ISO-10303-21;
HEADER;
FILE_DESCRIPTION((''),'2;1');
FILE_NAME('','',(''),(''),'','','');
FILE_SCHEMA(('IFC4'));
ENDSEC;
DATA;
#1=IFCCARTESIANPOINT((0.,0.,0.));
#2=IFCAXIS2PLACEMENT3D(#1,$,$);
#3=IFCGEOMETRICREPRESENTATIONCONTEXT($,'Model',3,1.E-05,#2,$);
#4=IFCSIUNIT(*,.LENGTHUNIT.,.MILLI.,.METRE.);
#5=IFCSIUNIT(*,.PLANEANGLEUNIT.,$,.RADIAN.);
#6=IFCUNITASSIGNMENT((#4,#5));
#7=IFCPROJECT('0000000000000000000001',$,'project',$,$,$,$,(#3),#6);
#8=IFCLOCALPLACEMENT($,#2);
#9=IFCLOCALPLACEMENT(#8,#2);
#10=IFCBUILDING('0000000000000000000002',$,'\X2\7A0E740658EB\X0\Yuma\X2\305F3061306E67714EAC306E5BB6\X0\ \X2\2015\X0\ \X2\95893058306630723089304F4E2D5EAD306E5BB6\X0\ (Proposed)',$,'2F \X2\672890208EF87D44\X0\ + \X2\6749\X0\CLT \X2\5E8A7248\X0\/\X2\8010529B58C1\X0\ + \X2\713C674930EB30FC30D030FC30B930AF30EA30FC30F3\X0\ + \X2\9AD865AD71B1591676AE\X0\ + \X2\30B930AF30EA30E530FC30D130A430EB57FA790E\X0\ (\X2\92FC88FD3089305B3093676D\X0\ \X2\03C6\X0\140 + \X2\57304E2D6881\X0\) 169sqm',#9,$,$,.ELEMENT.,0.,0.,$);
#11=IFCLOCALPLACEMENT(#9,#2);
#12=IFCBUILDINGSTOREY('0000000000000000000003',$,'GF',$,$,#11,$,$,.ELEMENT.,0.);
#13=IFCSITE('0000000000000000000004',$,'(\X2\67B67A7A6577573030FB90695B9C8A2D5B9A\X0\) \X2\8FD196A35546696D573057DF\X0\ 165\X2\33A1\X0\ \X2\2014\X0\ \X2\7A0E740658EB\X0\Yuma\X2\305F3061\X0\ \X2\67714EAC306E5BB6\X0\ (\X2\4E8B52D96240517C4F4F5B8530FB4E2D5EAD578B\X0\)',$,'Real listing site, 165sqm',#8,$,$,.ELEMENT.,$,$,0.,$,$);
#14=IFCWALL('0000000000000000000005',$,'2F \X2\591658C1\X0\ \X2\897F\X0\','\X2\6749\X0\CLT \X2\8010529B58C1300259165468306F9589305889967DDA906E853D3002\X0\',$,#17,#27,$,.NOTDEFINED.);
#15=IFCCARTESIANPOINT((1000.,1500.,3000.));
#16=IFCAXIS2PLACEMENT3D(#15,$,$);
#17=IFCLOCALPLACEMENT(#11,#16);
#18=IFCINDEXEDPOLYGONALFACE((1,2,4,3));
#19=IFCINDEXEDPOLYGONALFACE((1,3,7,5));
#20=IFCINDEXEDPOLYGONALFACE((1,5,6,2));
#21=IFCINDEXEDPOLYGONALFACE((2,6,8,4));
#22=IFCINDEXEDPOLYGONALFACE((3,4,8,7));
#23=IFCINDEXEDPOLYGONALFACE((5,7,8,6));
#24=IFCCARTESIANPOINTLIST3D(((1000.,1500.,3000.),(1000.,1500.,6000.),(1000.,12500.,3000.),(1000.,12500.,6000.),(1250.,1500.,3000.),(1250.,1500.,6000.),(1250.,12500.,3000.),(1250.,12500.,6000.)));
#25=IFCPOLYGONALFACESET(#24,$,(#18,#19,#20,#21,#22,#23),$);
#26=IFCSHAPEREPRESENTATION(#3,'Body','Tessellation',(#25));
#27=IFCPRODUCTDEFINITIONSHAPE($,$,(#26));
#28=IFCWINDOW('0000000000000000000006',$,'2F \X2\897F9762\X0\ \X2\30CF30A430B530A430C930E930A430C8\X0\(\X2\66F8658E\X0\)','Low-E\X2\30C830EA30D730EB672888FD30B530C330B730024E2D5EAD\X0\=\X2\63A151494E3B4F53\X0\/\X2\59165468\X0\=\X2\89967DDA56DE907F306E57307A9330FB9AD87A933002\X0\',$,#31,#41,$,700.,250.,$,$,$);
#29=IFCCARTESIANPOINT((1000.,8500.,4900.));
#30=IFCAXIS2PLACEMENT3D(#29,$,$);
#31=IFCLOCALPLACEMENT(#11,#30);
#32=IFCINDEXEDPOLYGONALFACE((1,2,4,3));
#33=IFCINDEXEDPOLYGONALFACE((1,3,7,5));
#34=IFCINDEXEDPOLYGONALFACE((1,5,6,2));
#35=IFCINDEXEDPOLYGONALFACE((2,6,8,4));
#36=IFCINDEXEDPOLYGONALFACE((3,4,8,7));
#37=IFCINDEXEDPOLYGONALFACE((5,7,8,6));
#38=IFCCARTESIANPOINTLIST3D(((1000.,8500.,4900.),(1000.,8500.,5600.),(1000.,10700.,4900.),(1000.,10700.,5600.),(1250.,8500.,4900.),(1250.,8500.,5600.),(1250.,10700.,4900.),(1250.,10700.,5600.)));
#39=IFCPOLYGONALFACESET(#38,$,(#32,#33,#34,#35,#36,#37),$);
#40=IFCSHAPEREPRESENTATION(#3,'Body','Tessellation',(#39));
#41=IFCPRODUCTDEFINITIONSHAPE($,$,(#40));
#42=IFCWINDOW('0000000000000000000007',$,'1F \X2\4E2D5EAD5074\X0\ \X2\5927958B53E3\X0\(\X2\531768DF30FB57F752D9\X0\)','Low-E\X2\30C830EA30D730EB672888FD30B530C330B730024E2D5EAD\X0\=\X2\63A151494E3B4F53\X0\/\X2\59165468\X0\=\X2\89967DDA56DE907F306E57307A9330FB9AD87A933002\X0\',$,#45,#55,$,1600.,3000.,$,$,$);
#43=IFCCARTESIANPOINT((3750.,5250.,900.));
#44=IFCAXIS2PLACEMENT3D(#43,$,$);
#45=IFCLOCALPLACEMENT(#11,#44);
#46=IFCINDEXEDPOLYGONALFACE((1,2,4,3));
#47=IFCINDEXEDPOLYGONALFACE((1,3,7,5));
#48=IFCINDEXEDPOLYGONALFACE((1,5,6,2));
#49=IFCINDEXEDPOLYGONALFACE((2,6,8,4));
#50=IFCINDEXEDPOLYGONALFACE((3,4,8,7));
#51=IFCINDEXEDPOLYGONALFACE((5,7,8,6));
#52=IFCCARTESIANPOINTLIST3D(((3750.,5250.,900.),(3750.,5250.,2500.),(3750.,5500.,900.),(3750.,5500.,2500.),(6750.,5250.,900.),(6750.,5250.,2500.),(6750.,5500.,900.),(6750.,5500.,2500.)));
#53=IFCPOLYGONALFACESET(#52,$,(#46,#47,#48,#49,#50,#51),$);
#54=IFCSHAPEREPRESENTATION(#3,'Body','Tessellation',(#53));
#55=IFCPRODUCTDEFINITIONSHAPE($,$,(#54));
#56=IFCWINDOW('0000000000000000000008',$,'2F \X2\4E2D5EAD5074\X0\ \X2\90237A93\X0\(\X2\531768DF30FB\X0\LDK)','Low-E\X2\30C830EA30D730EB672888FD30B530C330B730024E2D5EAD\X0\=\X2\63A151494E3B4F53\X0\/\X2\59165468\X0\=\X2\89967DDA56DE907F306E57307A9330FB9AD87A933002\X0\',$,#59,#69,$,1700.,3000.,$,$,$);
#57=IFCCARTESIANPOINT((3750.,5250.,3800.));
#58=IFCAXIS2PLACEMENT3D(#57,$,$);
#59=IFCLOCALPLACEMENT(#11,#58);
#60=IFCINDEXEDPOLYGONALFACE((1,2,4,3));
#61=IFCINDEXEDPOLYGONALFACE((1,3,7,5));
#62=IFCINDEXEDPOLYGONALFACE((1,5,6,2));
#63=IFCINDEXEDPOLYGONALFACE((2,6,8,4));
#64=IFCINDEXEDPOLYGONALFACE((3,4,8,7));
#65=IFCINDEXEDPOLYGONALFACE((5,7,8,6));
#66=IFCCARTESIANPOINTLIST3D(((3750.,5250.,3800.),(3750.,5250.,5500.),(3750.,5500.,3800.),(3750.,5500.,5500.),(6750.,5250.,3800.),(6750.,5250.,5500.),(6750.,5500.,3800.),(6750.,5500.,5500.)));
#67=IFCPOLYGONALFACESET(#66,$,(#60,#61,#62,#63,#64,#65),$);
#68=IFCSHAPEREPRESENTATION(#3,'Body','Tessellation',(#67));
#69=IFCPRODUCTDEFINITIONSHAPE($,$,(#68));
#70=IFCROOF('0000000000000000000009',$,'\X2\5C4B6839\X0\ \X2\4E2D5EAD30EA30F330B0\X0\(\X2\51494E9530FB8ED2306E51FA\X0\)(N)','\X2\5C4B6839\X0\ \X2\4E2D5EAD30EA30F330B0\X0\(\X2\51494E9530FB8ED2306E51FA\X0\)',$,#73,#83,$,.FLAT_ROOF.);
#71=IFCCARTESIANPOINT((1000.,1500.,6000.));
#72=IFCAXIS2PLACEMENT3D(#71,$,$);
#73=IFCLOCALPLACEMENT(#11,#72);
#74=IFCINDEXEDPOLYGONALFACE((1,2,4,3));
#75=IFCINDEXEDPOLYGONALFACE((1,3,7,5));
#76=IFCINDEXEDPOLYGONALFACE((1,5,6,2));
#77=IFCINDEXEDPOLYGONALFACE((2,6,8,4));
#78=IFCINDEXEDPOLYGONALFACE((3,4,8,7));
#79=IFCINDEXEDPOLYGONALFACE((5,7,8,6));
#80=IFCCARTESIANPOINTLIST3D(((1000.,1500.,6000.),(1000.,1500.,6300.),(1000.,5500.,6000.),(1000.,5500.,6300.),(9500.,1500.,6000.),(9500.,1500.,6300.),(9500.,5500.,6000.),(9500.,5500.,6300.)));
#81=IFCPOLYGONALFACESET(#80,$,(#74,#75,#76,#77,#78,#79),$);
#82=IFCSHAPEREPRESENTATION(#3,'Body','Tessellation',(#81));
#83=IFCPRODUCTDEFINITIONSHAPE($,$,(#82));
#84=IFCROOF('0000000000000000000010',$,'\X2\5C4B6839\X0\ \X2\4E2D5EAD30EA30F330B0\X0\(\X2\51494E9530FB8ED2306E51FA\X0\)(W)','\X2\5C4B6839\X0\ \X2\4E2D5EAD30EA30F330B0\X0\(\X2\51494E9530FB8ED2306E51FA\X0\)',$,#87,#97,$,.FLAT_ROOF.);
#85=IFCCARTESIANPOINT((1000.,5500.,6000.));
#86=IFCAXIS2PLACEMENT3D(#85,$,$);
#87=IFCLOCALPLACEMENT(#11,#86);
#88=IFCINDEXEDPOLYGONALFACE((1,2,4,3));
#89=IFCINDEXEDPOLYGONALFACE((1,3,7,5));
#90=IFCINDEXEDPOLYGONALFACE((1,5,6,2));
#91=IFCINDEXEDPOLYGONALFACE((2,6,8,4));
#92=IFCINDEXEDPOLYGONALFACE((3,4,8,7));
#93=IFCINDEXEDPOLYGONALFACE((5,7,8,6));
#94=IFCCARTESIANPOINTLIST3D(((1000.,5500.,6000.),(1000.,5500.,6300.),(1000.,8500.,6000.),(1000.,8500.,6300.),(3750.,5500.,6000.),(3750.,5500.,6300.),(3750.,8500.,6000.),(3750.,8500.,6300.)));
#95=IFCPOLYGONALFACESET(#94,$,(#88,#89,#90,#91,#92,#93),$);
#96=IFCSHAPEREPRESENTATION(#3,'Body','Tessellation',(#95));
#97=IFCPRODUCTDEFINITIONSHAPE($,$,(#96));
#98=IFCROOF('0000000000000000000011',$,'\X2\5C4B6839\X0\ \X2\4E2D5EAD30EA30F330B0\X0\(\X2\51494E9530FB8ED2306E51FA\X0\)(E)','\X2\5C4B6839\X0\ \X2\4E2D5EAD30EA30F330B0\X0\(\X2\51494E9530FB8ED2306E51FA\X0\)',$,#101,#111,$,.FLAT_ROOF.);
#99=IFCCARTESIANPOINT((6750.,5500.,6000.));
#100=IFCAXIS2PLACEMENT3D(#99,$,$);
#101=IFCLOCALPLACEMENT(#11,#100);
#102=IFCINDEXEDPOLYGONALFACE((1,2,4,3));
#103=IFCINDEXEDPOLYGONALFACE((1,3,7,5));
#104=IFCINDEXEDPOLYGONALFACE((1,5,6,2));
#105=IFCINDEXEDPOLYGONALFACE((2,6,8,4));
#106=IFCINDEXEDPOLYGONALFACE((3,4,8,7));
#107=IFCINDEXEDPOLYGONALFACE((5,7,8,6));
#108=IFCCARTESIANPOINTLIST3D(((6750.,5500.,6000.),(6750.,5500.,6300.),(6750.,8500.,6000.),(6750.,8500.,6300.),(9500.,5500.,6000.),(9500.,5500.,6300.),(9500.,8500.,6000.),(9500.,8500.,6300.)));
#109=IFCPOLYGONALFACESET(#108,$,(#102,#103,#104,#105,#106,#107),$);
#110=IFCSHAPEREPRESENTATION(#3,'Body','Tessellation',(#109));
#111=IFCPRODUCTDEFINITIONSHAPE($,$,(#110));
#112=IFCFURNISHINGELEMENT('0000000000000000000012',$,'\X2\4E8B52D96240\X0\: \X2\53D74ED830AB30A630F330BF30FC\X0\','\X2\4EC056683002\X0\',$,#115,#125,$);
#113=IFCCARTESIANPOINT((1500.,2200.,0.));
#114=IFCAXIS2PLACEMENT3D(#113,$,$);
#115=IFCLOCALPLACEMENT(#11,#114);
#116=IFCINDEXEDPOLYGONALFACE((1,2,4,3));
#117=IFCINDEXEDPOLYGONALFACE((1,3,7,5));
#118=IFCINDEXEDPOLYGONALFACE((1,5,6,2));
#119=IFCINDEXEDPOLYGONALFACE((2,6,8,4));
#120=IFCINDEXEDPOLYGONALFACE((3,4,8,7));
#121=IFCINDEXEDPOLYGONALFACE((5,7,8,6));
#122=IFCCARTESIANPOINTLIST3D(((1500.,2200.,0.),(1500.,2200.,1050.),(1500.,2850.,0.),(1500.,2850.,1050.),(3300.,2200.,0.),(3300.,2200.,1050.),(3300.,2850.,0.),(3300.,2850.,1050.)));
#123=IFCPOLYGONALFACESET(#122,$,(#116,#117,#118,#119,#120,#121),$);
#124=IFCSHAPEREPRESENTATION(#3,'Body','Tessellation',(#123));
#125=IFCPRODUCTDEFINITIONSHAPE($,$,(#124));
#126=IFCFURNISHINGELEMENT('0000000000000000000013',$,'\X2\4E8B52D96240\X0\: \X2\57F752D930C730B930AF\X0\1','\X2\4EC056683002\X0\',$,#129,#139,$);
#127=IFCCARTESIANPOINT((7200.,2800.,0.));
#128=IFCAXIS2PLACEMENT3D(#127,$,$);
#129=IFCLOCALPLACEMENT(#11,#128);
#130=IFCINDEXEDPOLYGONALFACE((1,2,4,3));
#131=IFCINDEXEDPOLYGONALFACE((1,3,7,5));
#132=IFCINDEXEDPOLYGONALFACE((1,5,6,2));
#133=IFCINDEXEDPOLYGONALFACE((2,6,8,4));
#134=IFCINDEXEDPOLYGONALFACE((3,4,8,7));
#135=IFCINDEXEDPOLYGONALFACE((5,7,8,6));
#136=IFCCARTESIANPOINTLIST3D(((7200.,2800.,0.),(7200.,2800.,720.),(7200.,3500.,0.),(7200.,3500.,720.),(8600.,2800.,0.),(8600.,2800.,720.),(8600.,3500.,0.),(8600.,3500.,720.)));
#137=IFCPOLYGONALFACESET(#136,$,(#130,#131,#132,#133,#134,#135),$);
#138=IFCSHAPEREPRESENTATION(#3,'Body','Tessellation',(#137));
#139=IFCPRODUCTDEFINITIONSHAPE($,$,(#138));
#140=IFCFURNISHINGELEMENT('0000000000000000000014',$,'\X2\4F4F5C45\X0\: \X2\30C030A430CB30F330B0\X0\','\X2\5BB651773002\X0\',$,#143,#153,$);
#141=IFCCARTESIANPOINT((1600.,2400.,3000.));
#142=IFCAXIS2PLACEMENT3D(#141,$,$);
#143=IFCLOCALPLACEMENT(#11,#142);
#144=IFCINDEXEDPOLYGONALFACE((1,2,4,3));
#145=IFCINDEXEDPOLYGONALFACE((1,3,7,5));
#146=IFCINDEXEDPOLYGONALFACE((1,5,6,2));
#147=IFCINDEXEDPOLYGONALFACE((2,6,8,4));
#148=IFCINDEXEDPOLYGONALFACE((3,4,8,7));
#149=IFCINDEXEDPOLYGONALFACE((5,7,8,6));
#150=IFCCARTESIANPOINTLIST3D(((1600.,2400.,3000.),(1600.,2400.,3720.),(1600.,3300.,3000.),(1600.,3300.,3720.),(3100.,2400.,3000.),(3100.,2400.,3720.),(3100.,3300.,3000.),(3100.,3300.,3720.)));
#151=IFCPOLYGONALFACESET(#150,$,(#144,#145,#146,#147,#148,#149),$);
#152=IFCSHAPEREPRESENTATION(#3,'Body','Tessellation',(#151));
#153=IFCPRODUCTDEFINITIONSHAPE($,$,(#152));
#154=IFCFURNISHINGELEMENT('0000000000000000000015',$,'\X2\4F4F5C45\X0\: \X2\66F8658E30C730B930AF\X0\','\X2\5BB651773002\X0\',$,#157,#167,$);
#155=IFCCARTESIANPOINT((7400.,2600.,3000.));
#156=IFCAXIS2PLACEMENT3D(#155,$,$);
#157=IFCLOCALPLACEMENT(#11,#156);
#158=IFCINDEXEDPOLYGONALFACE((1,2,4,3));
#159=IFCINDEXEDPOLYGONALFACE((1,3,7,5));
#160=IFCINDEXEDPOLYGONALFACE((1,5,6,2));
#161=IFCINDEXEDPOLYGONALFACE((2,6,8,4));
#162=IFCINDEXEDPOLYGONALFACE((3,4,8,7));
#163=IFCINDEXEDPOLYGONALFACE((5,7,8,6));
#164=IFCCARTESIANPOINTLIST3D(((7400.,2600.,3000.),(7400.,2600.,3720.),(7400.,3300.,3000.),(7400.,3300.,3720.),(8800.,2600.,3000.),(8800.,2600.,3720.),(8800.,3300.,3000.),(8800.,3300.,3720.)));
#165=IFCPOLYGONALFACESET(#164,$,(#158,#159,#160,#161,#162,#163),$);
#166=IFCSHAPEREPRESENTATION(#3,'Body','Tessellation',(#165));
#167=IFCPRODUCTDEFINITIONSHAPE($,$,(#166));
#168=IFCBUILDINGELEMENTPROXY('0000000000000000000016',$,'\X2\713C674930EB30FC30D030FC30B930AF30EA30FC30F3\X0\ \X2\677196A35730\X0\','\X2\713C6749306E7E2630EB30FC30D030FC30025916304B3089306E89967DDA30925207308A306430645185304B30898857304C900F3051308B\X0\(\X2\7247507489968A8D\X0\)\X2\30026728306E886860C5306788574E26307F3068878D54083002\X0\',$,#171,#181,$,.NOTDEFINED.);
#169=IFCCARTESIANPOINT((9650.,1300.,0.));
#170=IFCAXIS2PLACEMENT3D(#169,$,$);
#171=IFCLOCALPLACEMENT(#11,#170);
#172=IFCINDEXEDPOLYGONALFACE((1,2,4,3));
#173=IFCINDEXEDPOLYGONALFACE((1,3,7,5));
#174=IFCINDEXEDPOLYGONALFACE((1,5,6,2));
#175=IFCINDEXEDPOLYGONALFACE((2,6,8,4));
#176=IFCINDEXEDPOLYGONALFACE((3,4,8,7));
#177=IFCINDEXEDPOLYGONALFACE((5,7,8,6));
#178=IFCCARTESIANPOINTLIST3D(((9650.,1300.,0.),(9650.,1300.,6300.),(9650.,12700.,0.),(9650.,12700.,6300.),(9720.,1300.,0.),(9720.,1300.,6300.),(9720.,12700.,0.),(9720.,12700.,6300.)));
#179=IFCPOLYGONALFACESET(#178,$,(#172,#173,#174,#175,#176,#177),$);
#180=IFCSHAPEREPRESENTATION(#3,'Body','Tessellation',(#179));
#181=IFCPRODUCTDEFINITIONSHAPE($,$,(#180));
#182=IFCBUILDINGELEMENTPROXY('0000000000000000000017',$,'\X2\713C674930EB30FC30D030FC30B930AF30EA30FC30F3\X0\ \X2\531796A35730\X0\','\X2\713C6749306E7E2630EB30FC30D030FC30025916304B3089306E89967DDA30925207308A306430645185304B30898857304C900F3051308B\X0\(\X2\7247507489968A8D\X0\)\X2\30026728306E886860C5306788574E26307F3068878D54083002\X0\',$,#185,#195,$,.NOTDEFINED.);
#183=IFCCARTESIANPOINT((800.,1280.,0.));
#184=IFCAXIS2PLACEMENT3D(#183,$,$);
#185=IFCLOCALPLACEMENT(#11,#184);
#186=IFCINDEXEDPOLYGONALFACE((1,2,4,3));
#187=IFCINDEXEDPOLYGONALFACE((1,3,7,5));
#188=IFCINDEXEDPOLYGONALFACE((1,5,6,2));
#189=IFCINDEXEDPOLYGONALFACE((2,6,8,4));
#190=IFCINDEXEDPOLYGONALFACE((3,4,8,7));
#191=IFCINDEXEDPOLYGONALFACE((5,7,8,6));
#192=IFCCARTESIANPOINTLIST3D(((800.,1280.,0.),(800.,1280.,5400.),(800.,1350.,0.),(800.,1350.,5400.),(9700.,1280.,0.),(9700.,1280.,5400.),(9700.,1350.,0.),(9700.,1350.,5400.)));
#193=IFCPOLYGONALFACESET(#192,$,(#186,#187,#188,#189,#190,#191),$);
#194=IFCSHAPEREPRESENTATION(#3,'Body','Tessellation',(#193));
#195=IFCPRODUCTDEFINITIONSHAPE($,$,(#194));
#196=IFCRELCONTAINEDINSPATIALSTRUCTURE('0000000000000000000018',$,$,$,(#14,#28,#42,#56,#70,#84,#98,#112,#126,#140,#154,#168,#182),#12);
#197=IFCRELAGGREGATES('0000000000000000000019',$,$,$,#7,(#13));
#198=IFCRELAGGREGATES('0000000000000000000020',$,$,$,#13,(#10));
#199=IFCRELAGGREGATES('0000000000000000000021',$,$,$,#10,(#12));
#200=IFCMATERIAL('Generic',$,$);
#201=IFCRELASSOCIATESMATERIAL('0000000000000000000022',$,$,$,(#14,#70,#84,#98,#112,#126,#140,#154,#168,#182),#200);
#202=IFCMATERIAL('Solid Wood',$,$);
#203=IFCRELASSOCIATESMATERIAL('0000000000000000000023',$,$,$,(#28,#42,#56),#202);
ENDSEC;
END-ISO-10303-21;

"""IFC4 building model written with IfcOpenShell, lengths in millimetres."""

from ifc_helpers import new_model, si_unit, frame, frame_2d, origin, place, context, project, spatial, rectangle, extrude, material, element, fill, save


model = new_model("IFC4")

# Units and contexts
model_context = context("Model", 3, precision=1e-05, world=origin())
ifc_project = project(units=[si_unit("LENGTHUNIT", "METRE", prefix="MILLI"), si_unit("PLANEANGLEUNIT", "RADIAN")], contexts=[model_context])

# Site, building, storey
site_placement = place(None, origin())
site = spatial("IfcSite", under=ifc_project, at=site_placement, Name="(架空敷地・適宜設定) 近隣商業地域 165㎡ — 税理士Yumaたち 東京の家 (事務所兼住宅・中庭型)", ObjectType="Real listing site, 165sqm", CompositionType="ELEMENT", RefElevation=0.0)
building_placement = place(site_placement, origin())
building = spatial("IfcBuilding", under=site, at=building_placement, Name="税理士Yumaたちの東京の家 ― 閉じてひらく中庭の家 (Proposed)", ObjectType="2F 木造軸組 + 杉CLT 床版/耐力壁 + 焼杉ルーバースクリーン + 高断熱外皮 + スクリューパイル基礎 (鋼製らせん杭 φ140 + 地中梁) 169sqm", CompositionType="ELEMENT", ElevationOfRefHeight=0.0, ElevationOfTerrain=0.0)
storey_placement = place(building_placement, origin())
storey = spatial("IfcBuildingStorey", under=building, at=storey_placement, Name="GF", CompositionType="ELEMENT", Elevation=0.0)

# Shared definitions
ifc_material_1 = material(Name="Generic")

# Shared definitions
ifc_material_2 = material(Name="Solid Wood")

# Wall, opening, window
wall_1_placement = place(storey_placement, frame((1000.0, 1500.0, 3000.0)))
wall_1 = element("IfcWall", 1, at=wall_1_placement, inside=storey, material=ifc_material_1, Name="2F 外壁 西", Description="杉CLT 耐力壁。外周は閉じ視線遮蔽。", PredefinedType="NOTDEFINED", context=model_context, shape_type="SweptSolid", body=[
    extrude(rectangle(XDim=250.0, YDim=11000.0, at=frame_2d((125.0, 5500.0))), frame((1000.0, 1500.0, 3000.0)), (0.0, 0.0, 1.0), 3000.0),
])
opening_1_placement = place(storey_placement, frame((1000.0, 8500.0, 4900.0)))
opening_1 = element("IfcOpeningElement", 2, at=opening_1_placement, cuts=wall_1, PredefinedType="NOTDEFINED", context=model_context, shape_type="SweptSolid", body=[
    extrude(rectangle(XDim=250.0, YDim=2200.0, at=frame_2d((125.0, 1100.0))), frame((1000.0, 8500.0, 4900.0)), (0.0, 0.0, 1.0), 700.0),
])
window_1_placement = place(storey_placement, frame((1000.0, 8500.0, 4900.0)))
window_1 = element("IfcWindow", 3, at=window_1_placement, inside=storey, material=ifc_material_2, Name="2F 西面 ハイサイドライト(書斎)", Description="Low-Eトリプル木製サッシ。中庭=採光主体/外周=視線回避の地窓・高窓。", OverallHeight=700.0, OverallWidth=250.0, context=model_context, shape_type="SweptSolid", body=[
    extrude(rectangle(XDim=250.0, YDim=2200.0, at=frame_2d((125.0, 1100.0))), frame((1000.0, 8500.0, 4900.0)), (0.0, 0.0, 1.0), 700.0),
])
fill(opening_1, window_1)

# Windows
window_2_placement = place(storey_placement, frame((3750.0, 5250.0, 900.0)))
element("IfcWindow", 4, at=window_2_placement, inside=storey, material=ifc_material_2, Name="1F 中庭側 大開口(北棟・執務)", Description="Low-Eトリプル木製サッシ。中庭=採光主体/外周=視線回避の地窓・高窓。", OverallHeight=1600.0, OverallWidth=3000.0, context=model_context, shape_type="SweptSolid", body=[
    extrude(rectangle(XDim=3000.0, YDim=250.0, at=frame_2d((1500.0, 125.0))), frame((3750.0, 5250.0, 900.0)), (0.0, 0.0, 1.0), 1600.0),
])
window_3_placement = place(storey_placement, frame((3750.0, 5250.0, 3800.0)))
element("IfcWindow", 5, at=window_3_placement, inside=storey, material=ifc_material_2, Name="2F 中庭側 連窓(北棟・LDK)", Description="Low-Eトリプル木製サッシ。中庭=採光主体/外周=視線回避の地窓・高窓。", OverallHeight=1700.0, OverallWidth=3000.0, context=model_context, shape_type="SweptSolid", body=[
    extrude(rectangle(XDim=3000.0, YDim=250.0, at=frame_2d((1500.0, 125.0))), frame((3750.0, 5250.0, 3800.0)), (0.0, 0.0, 1.0), 1700.0),
])

# Roofs
roof_1_placement = place(storey_placement, frame((1000.0, 1500.0, 6000.0)))
element("IfcRoof", 6, at=roof_1_placement, inside=storey, material=ifc_material_1, Name="屋根 中庭リング(光井・軒の出)(N)", Description="屋根 中庭リング(光井・軒の出)", PredefinedType="FLAT_ROOF", context=model_context, shape_type="SweptSolid", body=[
    extrude(rectangle(XDim=8500.0, YDim=4000.0, at=frame_2d((4250.0, 2000.0))), frame((1000.0, 1500.0, 6000.0)), (0.0, 0.0, 1.0), 300.0),
])
roof_2_placement = place(storey_placement, frame((1000.0, 5500.0, 6000.0)))
element("IfcRoof", 7, at=roof_2_placement, inside=storey, material=ifc_material_1, Name="屋根 中庭リング(光井・軒の出)(W)", Description="屋根 中庭リング(光井・軒の出)", PredefinedType="FLAT_ROOF", context=model_context, shape_type="SweptSolid", body=[
    extrude(rectangle(XDim=2750.0, YDim=3000.0, at=frame_2d((1375.0, 1500.0))), frame((1000.0, 5500.0, 6000.0)), (0.0, 0.0, 1.0), 300.0),
])
roof_3_placement = place(storey_placement, frame((6750.0, 5500.0, 6000.0)))
element("IfcRoof", 8, at=roof_3_placement, inside=storey, material=ifc_material_1, Name="屋根 中庭リング(光井・軒の出)(E)", Description="屋根 中庭リング(光井・軒の出)", PredefinedType="FLAT_ROOF", context=model_context, shape_type="SweptSolid", body=[
    extrude(rectangle(XDim=2750.0, YDim=3000.0, at=frame_2d((1375.0, 1500.0))), frame((6750.0, 5500.0, 6000.0)), (0.0, 0.0, 1.0), 300.0),
])

# Furnishing elements
furnishing_1_placement = place(storey_placement, frame((1500.0, 2200.0, 0.0)))
element("IfcFurnishingElement", 9, at=furnishing_1_placement, inside=storey, material=ifc_material_1, Name="事務所: 受付カウンター", Description="什器。", context=model_context, shape_type="SweptSolid", body=[
    extrude(rectangle(XDim=1800.0, YDim=650.0, at=frame_2d((900.0, 325.0))), frame((1500.0, 2200.0, 0.0)), (0.0, 0.0, 1.0), 1050.0),
])
furnishing_2_placement = place(storey_placement, frame((7200.0, 2800.0, 0.0)))
element("IfcFurnishingElement", 10, at=furnishing_2_placement, inside=storey, material=ifc_material_1, Name="事務所: 執務デスク1", Description="什器。", context=model_context, shape_type="SweptSolid", body=[
    extrude(rectangle(XDim=1400.0, YDim=700.0, at=frame_2d((700.0, 350.0))), frame((7200.0, 2800.0, 0.0)), (0.0, 0.0, 1.0), 720.0),
])
furnishing_3_placement = place(storey_placement, frame((1600.0, 2400.0, 3000.0)))
element("IfcFurnishingElement", 11, at=furnishing_3_placement, inside=storey, material=ifc_material_1, Name="住居: ダイニング", Description="家具。", context=model_context, shape_type="SweptSolid", body=[
    extrude(rectangle(XDim=1500.0, YDim=900.0, at=frame_2d((750.0, 450.0))), frame((1600.0, 2400.0, 3000.0)), (0.0, 0.0, 1.0), 720.0),
])
furnishing_4_placement = place(storey_placement, frame((7400.0, 2600.0, 3000.0)))
element("IfcFurnishingElement", 12, at=furnishing_4_placement, inside=storey, material=ifc_material_1, Name="住居: 書斎デスク", Description="家具。", context=model_context, shape_type="SweptSolid", body=[
    extrude(rectangle(XDim=1400.0, YDim=700.0, at=frame_2d((700.0, 350.0))), frame((7400.0, 2600.0, 3000.0)), (0.0, 0.0, 1.0), 720.0),
])

# Building element proxies
proxy_1_placement = place(storey_placement, frame((9650.0, 1300.0, 0.0)))
element("IfcBuildingElementProxy", 13, at=proxy_1_placement, inside=storey, material=ifc_material_1, Name="焼杉ルーバースクリーン 東隣地", Description="焼杉の縦ルーバー。外からの視線を切りつつ内から街が透ける(片側視認)。木の表情で街並みと融合。", PredefinedType="NOTDEFINED", context=model_context, shape_type="SweptSolid", body=[
    extrude(rectangle(XDim=70.0, YDim=11400.0, at=frame_2d((35.0, 5700.0))), frame((9650.0, 1300.0, 0.0)), (0.0, 0.0, 1.0), 6300.0),
])
proxy_2_placement = place(storey_placement, frame((800.0, 1280.0, 0.0)))
element("IfcBuildingElementProxy", 14, at=proxy_2_placement, inside=storey, material=ifc_material_1, Name="焼杉ルーバースクリーン 北隣地", Description="焼杉の縦ルーバー。外からの視線を切りつつ内から街が透ける(片側視認)。木の表情で街並みと融合。", PredefinedType="NOTDEFINED", context=model_context, shape_type="SweptSolid", body=[
    extrude(rectangle(XDim=8900.0, YDim=70.0, at=frame_2d((4450.0, 35.0))), frame((800.0, 1280.0, 0.0)), (0.0, 0.0, 1.0), 5400.0),
])

save(model, "model.ifc")
